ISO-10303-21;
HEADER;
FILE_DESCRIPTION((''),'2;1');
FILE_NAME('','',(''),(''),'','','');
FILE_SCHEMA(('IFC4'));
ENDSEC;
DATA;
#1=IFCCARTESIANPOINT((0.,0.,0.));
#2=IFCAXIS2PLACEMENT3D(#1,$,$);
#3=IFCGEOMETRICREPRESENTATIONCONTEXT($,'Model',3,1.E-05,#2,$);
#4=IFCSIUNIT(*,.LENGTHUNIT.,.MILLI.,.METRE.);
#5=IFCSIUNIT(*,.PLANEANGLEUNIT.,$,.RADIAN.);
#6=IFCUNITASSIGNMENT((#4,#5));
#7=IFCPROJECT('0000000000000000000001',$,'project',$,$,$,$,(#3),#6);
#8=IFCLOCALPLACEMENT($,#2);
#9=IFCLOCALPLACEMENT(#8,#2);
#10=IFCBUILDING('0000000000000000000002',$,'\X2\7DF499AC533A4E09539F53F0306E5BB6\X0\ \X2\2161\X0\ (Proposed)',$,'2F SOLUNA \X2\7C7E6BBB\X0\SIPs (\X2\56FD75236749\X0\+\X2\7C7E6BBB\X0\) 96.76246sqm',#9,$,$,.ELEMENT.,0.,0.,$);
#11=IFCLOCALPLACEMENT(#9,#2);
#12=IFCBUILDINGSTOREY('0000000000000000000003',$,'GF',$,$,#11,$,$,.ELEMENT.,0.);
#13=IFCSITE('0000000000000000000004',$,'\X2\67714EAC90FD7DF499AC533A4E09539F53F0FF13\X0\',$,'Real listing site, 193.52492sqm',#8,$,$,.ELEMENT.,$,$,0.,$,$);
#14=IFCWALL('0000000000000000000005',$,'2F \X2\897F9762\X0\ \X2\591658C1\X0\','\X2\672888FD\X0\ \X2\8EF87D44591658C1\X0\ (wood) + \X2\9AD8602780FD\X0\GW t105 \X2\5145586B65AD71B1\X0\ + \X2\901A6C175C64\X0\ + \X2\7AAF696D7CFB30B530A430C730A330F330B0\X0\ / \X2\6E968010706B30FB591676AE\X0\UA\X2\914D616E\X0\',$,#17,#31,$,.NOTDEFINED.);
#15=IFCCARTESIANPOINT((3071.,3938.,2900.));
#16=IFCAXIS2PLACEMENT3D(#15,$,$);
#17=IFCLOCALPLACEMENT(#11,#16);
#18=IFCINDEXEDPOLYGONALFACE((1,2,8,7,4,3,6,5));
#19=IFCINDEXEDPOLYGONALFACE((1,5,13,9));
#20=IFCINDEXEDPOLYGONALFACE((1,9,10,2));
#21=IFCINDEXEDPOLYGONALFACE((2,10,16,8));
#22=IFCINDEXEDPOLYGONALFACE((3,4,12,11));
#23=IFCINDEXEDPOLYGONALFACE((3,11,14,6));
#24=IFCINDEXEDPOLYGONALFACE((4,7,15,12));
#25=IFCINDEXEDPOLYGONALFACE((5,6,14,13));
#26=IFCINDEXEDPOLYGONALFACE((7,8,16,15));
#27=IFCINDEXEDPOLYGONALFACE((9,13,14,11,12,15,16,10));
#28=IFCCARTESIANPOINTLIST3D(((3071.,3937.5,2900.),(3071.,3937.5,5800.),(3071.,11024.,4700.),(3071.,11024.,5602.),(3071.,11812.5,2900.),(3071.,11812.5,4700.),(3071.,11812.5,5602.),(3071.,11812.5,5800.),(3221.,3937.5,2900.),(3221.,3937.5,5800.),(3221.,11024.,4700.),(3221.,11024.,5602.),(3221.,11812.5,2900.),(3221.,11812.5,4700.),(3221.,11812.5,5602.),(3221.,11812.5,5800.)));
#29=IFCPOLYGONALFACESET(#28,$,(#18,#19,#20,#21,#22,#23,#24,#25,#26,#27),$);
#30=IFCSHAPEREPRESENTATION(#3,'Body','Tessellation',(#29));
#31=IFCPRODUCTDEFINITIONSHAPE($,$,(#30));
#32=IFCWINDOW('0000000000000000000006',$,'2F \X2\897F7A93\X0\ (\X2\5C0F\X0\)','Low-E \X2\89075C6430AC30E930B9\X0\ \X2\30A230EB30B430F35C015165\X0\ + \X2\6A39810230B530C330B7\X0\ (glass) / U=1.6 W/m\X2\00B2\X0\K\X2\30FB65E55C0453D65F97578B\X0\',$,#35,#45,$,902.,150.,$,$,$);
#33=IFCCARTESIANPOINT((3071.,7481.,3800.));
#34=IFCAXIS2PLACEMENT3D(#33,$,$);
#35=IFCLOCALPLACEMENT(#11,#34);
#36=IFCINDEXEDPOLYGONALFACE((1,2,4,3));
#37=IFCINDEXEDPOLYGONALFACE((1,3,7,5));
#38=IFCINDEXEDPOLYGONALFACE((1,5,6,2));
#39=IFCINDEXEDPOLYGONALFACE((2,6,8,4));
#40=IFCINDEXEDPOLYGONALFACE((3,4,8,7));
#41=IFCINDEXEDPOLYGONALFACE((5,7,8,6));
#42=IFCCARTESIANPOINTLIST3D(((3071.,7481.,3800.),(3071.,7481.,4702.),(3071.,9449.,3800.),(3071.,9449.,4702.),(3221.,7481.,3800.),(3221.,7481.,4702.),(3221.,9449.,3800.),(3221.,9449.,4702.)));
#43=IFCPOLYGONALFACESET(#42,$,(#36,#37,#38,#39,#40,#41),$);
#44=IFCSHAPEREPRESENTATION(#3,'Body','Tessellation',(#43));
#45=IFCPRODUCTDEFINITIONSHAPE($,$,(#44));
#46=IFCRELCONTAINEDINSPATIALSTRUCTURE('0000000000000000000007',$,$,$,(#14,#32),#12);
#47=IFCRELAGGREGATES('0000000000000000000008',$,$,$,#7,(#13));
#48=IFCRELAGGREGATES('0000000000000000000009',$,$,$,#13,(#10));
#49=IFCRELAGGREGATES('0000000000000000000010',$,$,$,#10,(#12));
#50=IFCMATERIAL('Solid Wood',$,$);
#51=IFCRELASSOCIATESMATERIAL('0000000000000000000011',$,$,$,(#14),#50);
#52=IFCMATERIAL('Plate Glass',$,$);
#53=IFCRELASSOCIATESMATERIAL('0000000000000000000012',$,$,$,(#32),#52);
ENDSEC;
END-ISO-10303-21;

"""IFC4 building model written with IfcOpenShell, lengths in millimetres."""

from ifc_helpers import new_model, si_unit, frame, frame_2d, origin, place, context, project, spatial, rectangle, extrude, material, element, fill, save


model = new_model("IFC4")

# Units and contexts
model_context = context("Model", 3, precision=1e-05, world=origin())
ifc_project = project(units=[si_unit("LENGTHUNIT", "METRE", prefix="MILLI"), si_unit("PLANEANGLEUNIT", "RADIAN")], contexts=[model_context])

# Site, building, storey
site_placement = place(None, origin())
site = spatial("IfcSite", under=ifc_project, at=site_placement, Name="東京都練馬区三原台３", ObjectType="Real listing site, 193.52492sqm", CompositionType="ELEMENT", RefElevation=0.0)
building_placement = place(site_placement, origin())
building = spatial("IfcBuilding", under=site, at=building_placement, Name="練馬区三原台の家 Ⅱ (Proposed)", ObjectType="2F SOLUNA 籾殻SIPs (国産杉+籾殻) 96.76246sqm", CompositionType="ELEMENT", ElevationOfRefHeight=0.0, ElevationOfTerrain=0.0)
storey_placement = place(building_placement, origin())
storey = spatial("IfcBuildingStorey", under=building, at=storey_placement, Name="GF", CompositionType="ELEMENT", Elevation=0.0)

# Shared definitions
ifc_material_1 = material(Name="Solid Wood")

# Shared definitions
ifc_material_2 = material(Name="Plate Glass")

# Wall, opening, window
wall_1_placement = place(storey_placement, frame((3071.0, 3938.0, 2900.0)))
wall_1 = element("IfcWall", 1, at=wall_1_placement, inside=storey, material=ifc_material_1, Name="2F 西面 外壁", Description="木製 軸組外壁 (wood) + 高性能GW t105 充填断熱 + 通気層 + 窯業系サイディング / 準耐火・外皮UA配慮", PredefinedType="NOTDEFINED", context=model_context, shape_type="SweptSolid", body=[
    extrude(rectangle(XDim=150.0, YDim=7875.0, at=frame_2d((75.0, 3937.0))), frame((3071.0, 3938.0, 2900.0)), (0.0, 0.0, 1.0), 2900.0),
])
opening_1_placement = place(storey_placement, frame((3071.0, 7481.0, 3800.0)))
opening_1 = element("IfcOpeningElement", 2, at=opening_1_placement, cuts=wall_1, PredefinedType="NOTDEFINED", context=model_context, shape_type="SweptSolid", body=[
    extrude(rectangle(XDim=150.0, YDim=1968.0, at=frame_2d((75.0, 984.0))), frame((3071.0, 7481.0, 3800.0)), (0.0, 0.0, 1.0), 902.0),
])
window_1_placement = place(storey_placement, frame((3071.0, 7481.0, 3800.0)))
window_1 = element("IfcWindow", 3, at=window_1_placement, inside=storey, material=ifc_material_2, Name="2F 西窓 (小)", Description="Low-E 複層ガラス アルゴン封入 + 樹脂サッシ (glass) / U=1.6 W/m²K・日射取得型", OverallHeight=902.0, OverallWidth=150.0, context=model_context, shape_type="SweptSolid", body=[
    extrude(rectangle(XDim=150.0, YDim=1968.0, at=frame_2d((75.0, 984.0))), frame((3071.0, 7481.0, 3800.0)), (0.0, 0.0, 1.0), 902.0),
])
fill(opening_1, window_1)

save(model, "model.ifc")
